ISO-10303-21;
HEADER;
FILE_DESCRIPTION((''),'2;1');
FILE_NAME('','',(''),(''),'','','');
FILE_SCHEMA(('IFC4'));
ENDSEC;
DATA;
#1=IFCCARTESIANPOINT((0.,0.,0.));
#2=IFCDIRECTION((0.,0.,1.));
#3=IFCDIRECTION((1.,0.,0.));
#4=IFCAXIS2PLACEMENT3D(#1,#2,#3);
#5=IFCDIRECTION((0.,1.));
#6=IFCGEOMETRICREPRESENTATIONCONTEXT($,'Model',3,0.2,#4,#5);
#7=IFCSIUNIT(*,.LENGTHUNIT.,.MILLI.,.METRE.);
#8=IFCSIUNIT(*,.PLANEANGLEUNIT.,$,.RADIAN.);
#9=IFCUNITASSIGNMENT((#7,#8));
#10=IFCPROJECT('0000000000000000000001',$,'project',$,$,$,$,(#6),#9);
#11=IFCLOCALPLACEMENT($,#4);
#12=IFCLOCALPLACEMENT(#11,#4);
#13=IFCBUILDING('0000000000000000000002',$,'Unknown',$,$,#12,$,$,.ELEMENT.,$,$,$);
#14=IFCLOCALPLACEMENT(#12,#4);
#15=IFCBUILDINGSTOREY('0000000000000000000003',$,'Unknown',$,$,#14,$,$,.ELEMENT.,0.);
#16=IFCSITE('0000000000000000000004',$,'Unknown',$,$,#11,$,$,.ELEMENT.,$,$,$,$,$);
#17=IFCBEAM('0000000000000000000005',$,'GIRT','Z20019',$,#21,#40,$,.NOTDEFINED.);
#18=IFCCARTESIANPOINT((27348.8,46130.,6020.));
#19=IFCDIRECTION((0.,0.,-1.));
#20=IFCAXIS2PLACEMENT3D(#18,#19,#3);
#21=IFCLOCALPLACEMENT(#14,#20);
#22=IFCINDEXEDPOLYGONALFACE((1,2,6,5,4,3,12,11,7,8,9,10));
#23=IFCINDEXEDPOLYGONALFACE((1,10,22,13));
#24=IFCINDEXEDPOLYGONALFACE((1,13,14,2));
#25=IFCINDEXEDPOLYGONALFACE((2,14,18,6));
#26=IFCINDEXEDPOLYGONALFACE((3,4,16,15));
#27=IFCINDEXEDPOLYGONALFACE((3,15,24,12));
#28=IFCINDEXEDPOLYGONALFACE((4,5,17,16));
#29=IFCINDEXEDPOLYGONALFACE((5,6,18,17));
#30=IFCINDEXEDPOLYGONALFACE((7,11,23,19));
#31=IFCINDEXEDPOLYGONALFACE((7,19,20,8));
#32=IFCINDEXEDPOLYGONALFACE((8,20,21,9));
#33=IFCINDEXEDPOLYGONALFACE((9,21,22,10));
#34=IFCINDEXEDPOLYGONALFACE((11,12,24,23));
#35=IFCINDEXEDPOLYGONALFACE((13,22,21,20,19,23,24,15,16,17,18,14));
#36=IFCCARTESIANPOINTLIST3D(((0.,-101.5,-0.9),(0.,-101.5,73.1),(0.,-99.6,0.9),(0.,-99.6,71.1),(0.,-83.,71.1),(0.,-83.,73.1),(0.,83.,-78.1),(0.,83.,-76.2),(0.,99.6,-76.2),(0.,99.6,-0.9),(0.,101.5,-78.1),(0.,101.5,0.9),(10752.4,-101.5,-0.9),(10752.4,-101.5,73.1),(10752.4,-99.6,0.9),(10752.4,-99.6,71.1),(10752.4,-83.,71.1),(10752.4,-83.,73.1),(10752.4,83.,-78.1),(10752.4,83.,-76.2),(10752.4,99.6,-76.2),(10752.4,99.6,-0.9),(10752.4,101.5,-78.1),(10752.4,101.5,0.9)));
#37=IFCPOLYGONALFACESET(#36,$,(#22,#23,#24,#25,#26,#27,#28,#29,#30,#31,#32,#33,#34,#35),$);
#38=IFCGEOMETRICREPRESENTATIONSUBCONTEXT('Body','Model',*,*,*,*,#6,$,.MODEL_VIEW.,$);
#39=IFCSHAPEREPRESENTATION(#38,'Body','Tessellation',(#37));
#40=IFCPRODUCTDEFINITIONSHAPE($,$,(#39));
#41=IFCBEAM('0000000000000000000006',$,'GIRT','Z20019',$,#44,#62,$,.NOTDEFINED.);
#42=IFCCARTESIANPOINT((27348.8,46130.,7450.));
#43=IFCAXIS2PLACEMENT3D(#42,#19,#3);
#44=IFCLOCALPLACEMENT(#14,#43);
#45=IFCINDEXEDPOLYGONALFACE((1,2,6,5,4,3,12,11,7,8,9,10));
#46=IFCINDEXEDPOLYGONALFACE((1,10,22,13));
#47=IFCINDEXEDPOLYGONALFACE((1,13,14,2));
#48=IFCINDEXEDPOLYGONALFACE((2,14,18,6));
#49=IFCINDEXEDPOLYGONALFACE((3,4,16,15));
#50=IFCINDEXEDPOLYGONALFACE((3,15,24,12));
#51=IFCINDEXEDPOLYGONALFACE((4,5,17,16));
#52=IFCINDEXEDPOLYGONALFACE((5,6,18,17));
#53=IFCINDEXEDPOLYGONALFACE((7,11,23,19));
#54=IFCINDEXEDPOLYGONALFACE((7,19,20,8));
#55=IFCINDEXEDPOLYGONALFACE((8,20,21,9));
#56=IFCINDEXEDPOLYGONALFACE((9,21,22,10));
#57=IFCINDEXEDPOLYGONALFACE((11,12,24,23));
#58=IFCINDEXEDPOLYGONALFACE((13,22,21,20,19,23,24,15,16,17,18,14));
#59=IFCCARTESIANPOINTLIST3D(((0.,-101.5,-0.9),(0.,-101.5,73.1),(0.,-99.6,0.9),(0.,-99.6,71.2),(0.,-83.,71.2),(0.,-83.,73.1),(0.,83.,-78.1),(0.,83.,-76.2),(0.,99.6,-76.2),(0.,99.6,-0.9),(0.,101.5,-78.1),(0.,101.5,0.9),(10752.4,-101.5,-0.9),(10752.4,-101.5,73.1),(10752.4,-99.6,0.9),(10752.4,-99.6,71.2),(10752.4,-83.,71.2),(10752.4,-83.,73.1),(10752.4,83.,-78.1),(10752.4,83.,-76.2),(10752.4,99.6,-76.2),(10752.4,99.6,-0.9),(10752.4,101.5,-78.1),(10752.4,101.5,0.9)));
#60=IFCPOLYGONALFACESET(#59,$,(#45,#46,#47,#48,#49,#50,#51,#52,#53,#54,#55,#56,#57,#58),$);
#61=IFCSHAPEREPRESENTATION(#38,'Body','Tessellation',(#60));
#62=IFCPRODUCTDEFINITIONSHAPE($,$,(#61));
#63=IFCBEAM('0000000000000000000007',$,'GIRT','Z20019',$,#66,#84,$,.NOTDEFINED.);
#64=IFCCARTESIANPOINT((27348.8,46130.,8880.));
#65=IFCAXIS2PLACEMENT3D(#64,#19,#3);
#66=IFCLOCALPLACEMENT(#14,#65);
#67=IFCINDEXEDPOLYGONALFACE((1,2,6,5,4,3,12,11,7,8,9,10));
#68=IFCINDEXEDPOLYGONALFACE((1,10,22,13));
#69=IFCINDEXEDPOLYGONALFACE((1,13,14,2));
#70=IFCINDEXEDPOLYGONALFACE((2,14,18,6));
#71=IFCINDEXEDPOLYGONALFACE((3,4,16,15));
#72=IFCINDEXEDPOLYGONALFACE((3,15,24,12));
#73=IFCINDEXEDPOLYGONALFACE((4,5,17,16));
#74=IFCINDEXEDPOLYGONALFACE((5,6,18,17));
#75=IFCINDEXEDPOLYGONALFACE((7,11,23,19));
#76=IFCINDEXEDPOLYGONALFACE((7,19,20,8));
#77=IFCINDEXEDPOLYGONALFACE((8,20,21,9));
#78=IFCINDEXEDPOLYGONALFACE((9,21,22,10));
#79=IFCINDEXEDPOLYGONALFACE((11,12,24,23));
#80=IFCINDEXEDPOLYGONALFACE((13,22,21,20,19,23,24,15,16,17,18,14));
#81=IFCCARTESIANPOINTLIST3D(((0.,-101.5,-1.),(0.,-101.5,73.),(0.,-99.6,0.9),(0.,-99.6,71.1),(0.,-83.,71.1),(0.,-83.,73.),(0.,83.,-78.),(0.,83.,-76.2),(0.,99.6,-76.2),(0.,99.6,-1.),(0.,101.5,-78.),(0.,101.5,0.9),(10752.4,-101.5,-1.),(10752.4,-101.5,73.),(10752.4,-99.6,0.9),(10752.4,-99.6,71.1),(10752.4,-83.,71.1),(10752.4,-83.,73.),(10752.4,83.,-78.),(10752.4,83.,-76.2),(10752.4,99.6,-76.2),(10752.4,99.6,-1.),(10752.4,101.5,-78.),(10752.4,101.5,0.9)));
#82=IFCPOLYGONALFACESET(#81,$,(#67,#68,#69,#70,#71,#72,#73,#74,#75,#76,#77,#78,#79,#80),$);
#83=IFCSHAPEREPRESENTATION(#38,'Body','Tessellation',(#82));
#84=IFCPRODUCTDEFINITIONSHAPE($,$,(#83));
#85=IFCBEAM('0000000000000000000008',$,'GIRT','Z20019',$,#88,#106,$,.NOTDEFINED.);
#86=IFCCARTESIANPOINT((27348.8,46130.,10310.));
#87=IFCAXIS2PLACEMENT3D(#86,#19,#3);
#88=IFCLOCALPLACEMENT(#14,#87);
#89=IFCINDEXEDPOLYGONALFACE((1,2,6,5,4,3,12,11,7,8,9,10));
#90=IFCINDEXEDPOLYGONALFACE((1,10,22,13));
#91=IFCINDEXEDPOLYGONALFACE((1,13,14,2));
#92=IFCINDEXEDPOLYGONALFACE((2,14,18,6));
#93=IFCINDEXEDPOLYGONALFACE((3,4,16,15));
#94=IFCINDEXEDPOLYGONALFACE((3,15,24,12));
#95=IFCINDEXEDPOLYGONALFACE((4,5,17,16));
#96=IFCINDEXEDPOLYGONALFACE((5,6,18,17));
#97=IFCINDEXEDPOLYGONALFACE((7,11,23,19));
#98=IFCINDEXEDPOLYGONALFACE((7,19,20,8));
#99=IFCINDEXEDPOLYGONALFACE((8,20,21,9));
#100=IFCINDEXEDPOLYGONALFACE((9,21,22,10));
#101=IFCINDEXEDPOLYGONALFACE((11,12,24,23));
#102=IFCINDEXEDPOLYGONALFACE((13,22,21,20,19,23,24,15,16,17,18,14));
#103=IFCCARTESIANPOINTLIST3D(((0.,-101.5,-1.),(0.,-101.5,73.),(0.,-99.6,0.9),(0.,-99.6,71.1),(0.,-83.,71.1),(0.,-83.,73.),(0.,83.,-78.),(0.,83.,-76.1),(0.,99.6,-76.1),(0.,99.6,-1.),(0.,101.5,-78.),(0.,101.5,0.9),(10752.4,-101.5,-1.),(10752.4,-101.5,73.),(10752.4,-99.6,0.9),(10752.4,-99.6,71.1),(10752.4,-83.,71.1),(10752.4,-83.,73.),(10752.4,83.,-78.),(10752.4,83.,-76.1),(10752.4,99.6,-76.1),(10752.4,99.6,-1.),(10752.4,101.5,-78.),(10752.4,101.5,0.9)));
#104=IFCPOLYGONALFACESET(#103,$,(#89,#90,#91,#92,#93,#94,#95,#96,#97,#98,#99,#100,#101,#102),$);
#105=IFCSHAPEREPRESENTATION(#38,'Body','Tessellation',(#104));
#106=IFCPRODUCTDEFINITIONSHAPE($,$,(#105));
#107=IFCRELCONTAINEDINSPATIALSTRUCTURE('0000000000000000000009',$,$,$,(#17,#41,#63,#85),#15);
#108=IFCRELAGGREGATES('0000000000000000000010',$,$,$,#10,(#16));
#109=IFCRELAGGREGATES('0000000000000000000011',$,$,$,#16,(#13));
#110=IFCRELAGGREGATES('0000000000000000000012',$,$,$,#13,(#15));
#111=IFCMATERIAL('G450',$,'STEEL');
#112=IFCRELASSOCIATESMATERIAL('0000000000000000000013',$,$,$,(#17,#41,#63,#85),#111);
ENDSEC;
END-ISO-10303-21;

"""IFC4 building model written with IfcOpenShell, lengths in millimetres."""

from ifc_helpers import new_model, si_unit, direction, frame, origin_with_axes, place, context, subcontext, project, spatial, line, indexed_curve, outline, extrude, material, element, save


model = new_model("IFC4")

# Units and contexts
model_context = context("Model", 3, precision=0.2, world=origin_with_axes(), true_north=direction((0.0, 1.0)))
body_context = subcontext(model_context, "Body", "Model", "MODEL_VIEW")
ifc_project = project(units=[si_unit("LENGTHUNIT", "METRE", prefix="MILLI"), si_unit("PLANEANGLEUNIT", "RADIAN")], contexts=[model_context])

# Site, building, storey
site_placement = place(None, origin_with_axes())
site = spatial("IfcSite", under=ifc_project, at=site_placement, Name="Unknown", CompositionType="ELEMENT")
building_placement = place(site_placement, origin_with_axes())
building = spatial("IfcBuilding", under=site, at=building_placement, Name="Unknown", CompositionType="ELEMENT")
storey_placement = place(building_placement, origin_with_axes())
storey = spatial("IfcBuildingStorey", under=building, at=storey_placement, Name="Unknown", CompositionType="ELEMENT", Elevation=0.0)

# Shared definitions
ifc_material_1 = material(Name="G450", Category="STEEL")

# Beams
for number, where, z_axis, x_axis, name in (
    (1, (27348.8, 46130.0, 6020.0), (0.0, 0.0, -1.0), (1.0, 0.0, 0.0), "GIRT"),
    (2, (27348.8, 46130.0, 7450.0), (0.0, 0.0, -1.0), (1.0, 0.0, 0.0), "GIRT"),
    (3, (27348.8, 46130.0, 8880.0), (0.0, 0.0, -1.0), (1.0, 0.0, 0.0), "GIRT"),
    (4, (27348.8, 46130.0, 10310.0), (0.0, 0.0, -1.0), (1.0, 0.0, 0.0), "GIRT"),
):
    element("IfcBeam", number, at=place(storey_placement, frame(where, z_axis=z_axis, x_axis=x_axis)), inside=storey, material=ifc_material_1, Name=name, Description="Z20019", PredefinedType="NOTDEFINED", context=body_context, shape_type="SolidModel", body=[
        extrude(outline(indexed_curve([(73.0, -101.5), (73.0, -83.0), (71.2, -83.0), (71.2, -99.6), (0.9, -99.6), (0.9, 101.5), (-78.0, 101.5), (-78.0, 83.0), (-76.2, 83.0), (-76.2, 99.6), (-0.9, 99.6), (-0.9, -101.5)], segments=[line(1, 2, 3, 4, 5, 6, 7, 8, 9, 10, 11, 12, 1)])), frame((0.0, 0.0, 0.0), z_axis=(-1.0, 0.0, 0.0), x_axis=(0.0, 0.0, 1.0)), (0.0, 0.0, -1.0), 10752.4),
    ])

save(model, "model.ifc")
